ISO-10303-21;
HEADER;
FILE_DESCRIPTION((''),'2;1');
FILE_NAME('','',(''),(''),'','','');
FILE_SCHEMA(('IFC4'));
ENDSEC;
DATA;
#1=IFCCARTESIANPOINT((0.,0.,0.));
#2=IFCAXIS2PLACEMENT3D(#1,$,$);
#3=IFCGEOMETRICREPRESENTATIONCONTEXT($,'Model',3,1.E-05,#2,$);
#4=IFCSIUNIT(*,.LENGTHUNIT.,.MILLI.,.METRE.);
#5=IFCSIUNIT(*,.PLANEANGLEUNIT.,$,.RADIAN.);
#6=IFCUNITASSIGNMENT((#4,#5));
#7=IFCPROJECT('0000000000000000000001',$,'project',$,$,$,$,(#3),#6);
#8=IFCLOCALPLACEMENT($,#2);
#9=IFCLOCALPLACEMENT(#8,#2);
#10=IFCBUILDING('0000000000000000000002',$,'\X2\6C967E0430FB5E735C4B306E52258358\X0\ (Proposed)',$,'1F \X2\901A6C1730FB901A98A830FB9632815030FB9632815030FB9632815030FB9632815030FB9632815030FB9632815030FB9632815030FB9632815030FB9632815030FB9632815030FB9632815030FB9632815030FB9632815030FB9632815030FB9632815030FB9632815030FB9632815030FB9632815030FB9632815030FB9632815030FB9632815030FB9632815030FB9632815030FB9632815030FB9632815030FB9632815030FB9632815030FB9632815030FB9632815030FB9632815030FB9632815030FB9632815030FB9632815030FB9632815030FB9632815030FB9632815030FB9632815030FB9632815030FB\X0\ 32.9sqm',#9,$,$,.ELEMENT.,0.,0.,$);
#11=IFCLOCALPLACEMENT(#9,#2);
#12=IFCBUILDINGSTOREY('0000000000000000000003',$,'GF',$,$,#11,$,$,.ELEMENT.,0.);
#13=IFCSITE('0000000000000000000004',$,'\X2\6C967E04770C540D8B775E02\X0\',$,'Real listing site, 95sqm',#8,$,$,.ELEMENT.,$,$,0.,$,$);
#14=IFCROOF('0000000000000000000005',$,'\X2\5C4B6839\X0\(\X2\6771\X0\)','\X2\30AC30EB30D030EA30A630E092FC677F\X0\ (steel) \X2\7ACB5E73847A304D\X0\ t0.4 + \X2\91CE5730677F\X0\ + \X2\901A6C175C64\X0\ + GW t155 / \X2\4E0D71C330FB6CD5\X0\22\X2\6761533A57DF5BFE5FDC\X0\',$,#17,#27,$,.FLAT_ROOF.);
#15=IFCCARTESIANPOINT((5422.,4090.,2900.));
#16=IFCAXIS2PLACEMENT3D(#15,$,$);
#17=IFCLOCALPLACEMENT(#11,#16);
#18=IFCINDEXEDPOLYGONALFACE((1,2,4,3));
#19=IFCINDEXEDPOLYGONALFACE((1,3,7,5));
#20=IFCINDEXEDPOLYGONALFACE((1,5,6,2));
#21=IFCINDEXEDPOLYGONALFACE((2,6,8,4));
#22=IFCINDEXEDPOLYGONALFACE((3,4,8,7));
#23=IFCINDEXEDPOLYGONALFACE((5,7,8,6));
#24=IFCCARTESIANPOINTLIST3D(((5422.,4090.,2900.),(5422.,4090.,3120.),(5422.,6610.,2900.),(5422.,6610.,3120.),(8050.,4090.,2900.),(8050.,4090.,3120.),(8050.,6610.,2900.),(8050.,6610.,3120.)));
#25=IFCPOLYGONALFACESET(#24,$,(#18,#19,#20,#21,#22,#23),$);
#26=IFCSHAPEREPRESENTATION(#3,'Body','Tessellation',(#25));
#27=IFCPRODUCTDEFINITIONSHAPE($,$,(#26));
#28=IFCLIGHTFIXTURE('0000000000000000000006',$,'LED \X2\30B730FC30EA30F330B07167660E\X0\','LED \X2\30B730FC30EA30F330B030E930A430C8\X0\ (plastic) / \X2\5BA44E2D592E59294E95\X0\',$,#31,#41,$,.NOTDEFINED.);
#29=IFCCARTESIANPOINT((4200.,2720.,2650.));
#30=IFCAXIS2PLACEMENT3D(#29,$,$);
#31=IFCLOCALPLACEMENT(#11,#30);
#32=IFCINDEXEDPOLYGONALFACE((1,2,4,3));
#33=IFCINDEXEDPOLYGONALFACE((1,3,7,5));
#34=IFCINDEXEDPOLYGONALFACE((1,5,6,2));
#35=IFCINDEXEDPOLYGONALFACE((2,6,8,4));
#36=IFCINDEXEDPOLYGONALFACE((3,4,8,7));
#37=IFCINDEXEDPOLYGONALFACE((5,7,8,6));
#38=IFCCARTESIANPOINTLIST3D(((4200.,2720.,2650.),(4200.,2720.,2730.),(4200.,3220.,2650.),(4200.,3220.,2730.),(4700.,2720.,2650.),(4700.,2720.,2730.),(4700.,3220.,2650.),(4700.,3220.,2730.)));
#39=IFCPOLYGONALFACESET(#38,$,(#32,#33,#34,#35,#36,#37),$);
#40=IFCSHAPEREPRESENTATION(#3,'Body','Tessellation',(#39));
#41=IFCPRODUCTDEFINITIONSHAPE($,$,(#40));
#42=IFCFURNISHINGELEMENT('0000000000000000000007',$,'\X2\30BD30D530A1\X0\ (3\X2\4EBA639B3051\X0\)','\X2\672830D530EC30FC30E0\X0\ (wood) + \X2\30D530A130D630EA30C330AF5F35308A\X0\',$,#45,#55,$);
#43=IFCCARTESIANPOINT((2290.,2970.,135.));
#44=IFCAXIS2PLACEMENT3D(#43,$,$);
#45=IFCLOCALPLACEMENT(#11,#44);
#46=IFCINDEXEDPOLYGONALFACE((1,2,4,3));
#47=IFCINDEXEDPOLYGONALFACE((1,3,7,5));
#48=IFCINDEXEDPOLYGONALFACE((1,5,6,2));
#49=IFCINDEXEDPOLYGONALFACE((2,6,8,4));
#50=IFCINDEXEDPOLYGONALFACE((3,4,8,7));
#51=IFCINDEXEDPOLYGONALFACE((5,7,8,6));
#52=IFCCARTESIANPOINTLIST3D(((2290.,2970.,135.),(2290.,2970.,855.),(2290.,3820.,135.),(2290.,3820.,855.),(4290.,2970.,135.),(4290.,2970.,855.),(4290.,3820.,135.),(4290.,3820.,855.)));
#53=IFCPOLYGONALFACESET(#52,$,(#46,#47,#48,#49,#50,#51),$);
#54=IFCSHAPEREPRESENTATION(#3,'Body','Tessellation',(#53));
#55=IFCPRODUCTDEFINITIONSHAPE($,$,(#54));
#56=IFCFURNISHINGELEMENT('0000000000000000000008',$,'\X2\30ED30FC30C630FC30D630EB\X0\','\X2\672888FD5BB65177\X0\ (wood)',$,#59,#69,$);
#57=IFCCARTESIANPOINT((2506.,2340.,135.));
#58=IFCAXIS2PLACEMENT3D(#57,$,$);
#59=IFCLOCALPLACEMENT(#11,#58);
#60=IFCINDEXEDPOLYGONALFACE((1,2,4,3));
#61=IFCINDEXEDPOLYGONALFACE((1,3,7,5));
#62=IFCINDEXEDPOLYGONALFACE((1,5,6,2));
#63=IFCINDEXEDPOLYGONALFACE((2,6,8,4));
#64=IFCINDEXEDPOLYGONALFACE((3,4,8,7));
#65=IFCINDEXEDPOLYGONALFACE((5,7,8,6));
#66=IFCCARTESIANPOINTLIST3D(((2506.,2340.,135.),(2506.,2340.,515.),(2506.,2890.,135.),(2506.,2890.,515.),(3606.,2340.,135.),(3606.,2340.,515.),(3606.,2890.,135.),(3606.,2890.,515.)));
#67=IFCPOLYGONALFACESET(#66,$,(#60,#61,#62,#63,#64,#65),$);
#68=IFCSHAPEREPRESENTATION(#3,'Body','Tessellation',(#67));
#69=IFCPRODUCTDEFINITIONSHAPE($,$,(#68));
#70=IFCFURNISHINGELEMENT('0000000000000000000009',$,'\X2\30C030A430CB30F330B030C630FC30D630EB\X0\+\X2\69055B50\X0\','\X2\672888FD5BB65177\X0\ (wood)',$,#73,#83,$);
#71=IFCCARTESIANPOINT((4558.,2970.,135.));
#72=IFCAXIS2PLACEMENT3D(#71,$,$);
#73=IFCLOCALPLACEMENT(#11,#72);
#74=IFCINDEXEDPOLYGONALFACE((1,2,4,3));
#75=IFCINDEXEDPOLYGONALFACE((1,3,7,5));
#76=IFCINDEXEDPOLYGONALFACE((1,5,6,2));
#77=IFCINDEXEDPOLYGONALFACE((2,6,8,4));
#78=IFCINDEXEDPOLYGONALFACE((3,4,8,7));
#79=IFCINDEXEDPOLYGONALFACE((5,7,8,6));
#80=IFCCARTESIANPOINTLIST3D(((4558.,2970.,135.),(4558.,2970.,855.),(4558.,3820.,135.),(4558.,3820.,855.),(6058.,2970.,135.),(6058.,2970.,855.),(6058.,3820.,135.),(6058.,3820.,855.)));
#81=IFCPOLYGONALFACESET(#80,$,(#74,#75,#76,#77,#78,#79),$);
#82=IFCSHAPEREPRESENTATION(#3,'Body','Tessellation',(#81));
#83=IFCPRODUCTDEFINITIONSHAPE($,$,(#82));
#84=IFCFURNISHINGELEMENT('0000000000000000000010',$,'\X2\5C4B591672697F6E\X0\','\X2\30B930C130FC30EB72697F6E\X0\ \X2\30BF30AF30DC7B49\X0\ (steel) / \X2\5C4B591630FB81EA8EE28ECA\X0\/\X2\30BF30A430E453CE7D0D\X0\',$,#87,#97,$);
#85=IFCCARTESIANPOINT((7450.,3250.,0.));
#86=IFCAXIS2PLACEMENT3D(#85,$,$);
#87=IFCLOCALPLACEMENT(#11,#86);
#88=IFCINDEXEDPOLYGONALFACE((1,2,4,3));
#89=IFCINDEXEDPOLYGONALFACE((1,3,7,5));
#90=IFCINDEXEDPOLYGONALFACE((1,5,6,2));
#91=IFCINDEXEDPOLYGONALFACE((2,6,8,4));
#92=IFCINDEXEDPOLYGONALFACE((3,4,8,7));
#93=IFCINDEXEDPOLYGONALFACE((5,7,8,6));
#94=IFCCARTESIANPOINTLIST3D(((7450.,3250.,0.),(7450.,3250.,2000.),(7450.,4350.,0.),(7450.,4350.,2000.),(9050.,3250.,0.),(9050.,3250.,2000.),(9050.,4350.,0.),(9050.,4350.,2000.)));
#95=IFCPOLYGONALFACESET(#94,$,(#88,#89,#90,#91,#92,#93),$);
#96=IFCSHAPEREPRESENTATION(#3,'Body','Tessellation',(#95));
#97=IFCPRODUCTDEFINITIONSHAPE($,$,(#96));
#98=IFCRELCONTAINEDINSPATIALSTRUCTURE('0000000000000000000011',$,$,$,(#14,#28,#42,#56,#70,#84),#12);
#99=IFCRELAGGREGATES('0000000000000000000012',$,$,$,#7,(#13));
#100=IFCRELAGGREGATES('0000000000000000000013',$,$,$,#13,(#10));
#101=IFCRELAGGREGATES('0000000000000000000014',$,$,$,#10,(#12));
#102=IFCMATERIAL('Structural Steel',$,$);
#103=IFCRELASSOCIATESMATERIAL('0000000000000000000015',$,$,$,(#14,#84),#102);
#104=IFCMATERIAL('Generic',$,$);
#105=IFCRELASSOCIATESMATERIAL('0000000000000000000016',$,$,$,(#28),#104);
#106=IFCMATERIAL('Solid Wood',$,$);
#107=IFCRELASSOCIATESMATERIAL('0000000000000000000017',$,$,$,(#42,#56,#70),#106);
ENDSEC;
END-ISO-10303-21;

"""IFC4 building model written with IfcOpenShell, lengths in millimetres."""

from ifc_helpers import new_model, si_unit, frame, frame_2d, origin, place, context, project, spatial, rectangle, extrude, material, element, save


model = new_model("IFC4")

# Units and contexts
model_context = context("Model", 3, precision=1e-05, world=origin())
ifc_project = project(units=[si_unit("LENGTHUNIT", "METRE", prefix="MILLI"), si_unit("PLANEANGLEUNIT", "RADIAN")], contexts=[model_context])

# Site, building, storey
site_placement = place(None, origin())
site = spatial("IfcSite", under=ifc_project, at=site_placement, Name="沖縄県名護市", ObjectType="Real listing site, 95sqm", CompositionType="ELEMENT", RefElevation=0.0)
building_placement = place(site_placement, origin())
building = spatial("IfcBuilding", under=site, at=building_placement, Name="沖縄・平屋の別荘 (Proposed)", ObjectType="1F 通気・通風・防腐・防腐・防腐・防腐・防腐・防腐・防腐・防腐・防腐・防腐・防腐・防腐・防腐・防腐・防腐・防腐・防腐・防腐・防腐・防腐・防腐・防腐・防腐・防腐・防腐・防腐・防腐・防腐・防腐・防腐・防腐・防腐・防腐・防腐・防腐・防腐・防腐・防腐・ 32.9sqm", CompositionType="ELEMENT", ElevationOfRefHeight=0.0, ElevationOfTerrain=0.0)
storey_placement = place(building_placement, origin())
storey = spatial("IfcBuildingStorey", under=building, at=storey_placement, Name="GF", CompositionType="ELEMENT", Elevation=0.0)

# Shared definitions
ifc_material_1 = material(Name="Solid Wood")

# Roof
ifc_material_2 = material(Name="Structural Steel")
roof_1_placement = place(storey_placement, frame((5422.0, 4090.0, 2900.0)))
element("IfcRoof", 1, at=roof_1_placement, inside=storey, material=ifc_material_2, Name="屋根(東)", Description="ガルバリウム鋼板 (steel) 立平葺き t0.4 + 野地板 + 通気層 + GW t155 / 不燃・法22条区域対応", PredefinedType="FLAT_ROOF", context=model_context, shape_type="SweptSolid", body=[
    extrude(rectangle(XDim=2628.0, YDim=2520.0, at=frame_2d((1314.0, 1260.0))), frame((5422.0, 4090.0, 2900.0)), (0.0, 0.0, 1.0), 220.0),
])

# Light fixture
ifc_material_3 = material(Name="Generic")
light_fixture_placement = place(storey_placement, frame((4200.0, 2720.0, 2650.0)))
element("IfcLightFixture", 2, at=light_fixture_placement, inside=storey, material=ifc_material_3, Name="LED シーリング照明", Description="LED シーリングライト (plastic) / 室中央天井", PredefinedType="NOTDEFINED", context=model_context, shape_type="SweptSolid", body=[
    extrude(rectangle(XDim=500.0, YDim=500.0, at=frame_2d((250.0, 250.0))), frame((4200.0, 2720.0, 2650.0)), (0.0, 0.0, 1.0), 80.0),
])

# Furnishing elements
furnishing_1_placement = place(storey_placement, frame((2290.0, 2970.0, 135.0)))
element("IfcFurnishingElement", 3, at=furnishing_1_placement, inside=storey, material=ifc_material_1, Name="ソファ (3人掛け)", Description="木フレーム (wood) + ファブリック張り", context=model_context, shape_type="SweptSolid", body=[
    extrude(rectangle(XDim=2000.0, YDim=850.0, at=frame_2d((1000.0, 425.0))), frame((2290.0, 2970.0, 135.0)), (0.0, 0.0, 1.0), 720.0),
])
furnishing_2_placement = place(storey_placement, frame((2506.0, 2340.0, 135.0)))
element("IfcFurnishingElement", 4, at=furnishing_2_placement, inside=storey, material=ifc_material_1, Name="ローテーブル", Description="木製家具 (wood)", context=model_context, shape_type="SweptSolid", body=[
    extrude(rectangle(XDim=1100.0, YDim=550.0, at=frame_2d((550.0, 275.0))), frame((2506.0, 2340.0, 135.0)), (0.0, 0.0, 1.0), 380.0),
])
furnishing_3_placement = place(storey_placement, frame((4558.0, 2970.0, 135.0)))
element("IfcFurnishingElement", 5, at=furnishing_3_placement, inside=storey, material=ifc_material_1, Name="ダイニングテーブル+椅子", Description="木製家具 (wood)", context=model_context, shape_type="SweptSolid", body=[
    extrude(rectangle(XDim=1500.0, YDim=850.0, at=frame_2d((750.0, 425.0))), frame((4558.0, 2970.0, 135.0)), (0.0, 0.0, 1.0), 720.0),
])
furnishing_4_placement = place(storey_placement, frame((7450.0, 3250.0, 0.0)))
element("IfcFurnishingElement", 6, at=furnishing_4_placement, inside=storey, material=ifc_material_2, Name="屋外物置", Description="スチール物置 タクボ等 (steel) / 屋外・自転車/タイヤ収納", context=model_context, shape_type="SweptSolid", body=[
    extrude(rectangle(XDim=1600.0, YDim=1100.0, at=frame_2d((800.0, 550.0))), frame((7450.0, 3250.0, 0.0)), (0.0, 0.0, 1.0), 2000.0),
])

save(model, "model.ifc")
